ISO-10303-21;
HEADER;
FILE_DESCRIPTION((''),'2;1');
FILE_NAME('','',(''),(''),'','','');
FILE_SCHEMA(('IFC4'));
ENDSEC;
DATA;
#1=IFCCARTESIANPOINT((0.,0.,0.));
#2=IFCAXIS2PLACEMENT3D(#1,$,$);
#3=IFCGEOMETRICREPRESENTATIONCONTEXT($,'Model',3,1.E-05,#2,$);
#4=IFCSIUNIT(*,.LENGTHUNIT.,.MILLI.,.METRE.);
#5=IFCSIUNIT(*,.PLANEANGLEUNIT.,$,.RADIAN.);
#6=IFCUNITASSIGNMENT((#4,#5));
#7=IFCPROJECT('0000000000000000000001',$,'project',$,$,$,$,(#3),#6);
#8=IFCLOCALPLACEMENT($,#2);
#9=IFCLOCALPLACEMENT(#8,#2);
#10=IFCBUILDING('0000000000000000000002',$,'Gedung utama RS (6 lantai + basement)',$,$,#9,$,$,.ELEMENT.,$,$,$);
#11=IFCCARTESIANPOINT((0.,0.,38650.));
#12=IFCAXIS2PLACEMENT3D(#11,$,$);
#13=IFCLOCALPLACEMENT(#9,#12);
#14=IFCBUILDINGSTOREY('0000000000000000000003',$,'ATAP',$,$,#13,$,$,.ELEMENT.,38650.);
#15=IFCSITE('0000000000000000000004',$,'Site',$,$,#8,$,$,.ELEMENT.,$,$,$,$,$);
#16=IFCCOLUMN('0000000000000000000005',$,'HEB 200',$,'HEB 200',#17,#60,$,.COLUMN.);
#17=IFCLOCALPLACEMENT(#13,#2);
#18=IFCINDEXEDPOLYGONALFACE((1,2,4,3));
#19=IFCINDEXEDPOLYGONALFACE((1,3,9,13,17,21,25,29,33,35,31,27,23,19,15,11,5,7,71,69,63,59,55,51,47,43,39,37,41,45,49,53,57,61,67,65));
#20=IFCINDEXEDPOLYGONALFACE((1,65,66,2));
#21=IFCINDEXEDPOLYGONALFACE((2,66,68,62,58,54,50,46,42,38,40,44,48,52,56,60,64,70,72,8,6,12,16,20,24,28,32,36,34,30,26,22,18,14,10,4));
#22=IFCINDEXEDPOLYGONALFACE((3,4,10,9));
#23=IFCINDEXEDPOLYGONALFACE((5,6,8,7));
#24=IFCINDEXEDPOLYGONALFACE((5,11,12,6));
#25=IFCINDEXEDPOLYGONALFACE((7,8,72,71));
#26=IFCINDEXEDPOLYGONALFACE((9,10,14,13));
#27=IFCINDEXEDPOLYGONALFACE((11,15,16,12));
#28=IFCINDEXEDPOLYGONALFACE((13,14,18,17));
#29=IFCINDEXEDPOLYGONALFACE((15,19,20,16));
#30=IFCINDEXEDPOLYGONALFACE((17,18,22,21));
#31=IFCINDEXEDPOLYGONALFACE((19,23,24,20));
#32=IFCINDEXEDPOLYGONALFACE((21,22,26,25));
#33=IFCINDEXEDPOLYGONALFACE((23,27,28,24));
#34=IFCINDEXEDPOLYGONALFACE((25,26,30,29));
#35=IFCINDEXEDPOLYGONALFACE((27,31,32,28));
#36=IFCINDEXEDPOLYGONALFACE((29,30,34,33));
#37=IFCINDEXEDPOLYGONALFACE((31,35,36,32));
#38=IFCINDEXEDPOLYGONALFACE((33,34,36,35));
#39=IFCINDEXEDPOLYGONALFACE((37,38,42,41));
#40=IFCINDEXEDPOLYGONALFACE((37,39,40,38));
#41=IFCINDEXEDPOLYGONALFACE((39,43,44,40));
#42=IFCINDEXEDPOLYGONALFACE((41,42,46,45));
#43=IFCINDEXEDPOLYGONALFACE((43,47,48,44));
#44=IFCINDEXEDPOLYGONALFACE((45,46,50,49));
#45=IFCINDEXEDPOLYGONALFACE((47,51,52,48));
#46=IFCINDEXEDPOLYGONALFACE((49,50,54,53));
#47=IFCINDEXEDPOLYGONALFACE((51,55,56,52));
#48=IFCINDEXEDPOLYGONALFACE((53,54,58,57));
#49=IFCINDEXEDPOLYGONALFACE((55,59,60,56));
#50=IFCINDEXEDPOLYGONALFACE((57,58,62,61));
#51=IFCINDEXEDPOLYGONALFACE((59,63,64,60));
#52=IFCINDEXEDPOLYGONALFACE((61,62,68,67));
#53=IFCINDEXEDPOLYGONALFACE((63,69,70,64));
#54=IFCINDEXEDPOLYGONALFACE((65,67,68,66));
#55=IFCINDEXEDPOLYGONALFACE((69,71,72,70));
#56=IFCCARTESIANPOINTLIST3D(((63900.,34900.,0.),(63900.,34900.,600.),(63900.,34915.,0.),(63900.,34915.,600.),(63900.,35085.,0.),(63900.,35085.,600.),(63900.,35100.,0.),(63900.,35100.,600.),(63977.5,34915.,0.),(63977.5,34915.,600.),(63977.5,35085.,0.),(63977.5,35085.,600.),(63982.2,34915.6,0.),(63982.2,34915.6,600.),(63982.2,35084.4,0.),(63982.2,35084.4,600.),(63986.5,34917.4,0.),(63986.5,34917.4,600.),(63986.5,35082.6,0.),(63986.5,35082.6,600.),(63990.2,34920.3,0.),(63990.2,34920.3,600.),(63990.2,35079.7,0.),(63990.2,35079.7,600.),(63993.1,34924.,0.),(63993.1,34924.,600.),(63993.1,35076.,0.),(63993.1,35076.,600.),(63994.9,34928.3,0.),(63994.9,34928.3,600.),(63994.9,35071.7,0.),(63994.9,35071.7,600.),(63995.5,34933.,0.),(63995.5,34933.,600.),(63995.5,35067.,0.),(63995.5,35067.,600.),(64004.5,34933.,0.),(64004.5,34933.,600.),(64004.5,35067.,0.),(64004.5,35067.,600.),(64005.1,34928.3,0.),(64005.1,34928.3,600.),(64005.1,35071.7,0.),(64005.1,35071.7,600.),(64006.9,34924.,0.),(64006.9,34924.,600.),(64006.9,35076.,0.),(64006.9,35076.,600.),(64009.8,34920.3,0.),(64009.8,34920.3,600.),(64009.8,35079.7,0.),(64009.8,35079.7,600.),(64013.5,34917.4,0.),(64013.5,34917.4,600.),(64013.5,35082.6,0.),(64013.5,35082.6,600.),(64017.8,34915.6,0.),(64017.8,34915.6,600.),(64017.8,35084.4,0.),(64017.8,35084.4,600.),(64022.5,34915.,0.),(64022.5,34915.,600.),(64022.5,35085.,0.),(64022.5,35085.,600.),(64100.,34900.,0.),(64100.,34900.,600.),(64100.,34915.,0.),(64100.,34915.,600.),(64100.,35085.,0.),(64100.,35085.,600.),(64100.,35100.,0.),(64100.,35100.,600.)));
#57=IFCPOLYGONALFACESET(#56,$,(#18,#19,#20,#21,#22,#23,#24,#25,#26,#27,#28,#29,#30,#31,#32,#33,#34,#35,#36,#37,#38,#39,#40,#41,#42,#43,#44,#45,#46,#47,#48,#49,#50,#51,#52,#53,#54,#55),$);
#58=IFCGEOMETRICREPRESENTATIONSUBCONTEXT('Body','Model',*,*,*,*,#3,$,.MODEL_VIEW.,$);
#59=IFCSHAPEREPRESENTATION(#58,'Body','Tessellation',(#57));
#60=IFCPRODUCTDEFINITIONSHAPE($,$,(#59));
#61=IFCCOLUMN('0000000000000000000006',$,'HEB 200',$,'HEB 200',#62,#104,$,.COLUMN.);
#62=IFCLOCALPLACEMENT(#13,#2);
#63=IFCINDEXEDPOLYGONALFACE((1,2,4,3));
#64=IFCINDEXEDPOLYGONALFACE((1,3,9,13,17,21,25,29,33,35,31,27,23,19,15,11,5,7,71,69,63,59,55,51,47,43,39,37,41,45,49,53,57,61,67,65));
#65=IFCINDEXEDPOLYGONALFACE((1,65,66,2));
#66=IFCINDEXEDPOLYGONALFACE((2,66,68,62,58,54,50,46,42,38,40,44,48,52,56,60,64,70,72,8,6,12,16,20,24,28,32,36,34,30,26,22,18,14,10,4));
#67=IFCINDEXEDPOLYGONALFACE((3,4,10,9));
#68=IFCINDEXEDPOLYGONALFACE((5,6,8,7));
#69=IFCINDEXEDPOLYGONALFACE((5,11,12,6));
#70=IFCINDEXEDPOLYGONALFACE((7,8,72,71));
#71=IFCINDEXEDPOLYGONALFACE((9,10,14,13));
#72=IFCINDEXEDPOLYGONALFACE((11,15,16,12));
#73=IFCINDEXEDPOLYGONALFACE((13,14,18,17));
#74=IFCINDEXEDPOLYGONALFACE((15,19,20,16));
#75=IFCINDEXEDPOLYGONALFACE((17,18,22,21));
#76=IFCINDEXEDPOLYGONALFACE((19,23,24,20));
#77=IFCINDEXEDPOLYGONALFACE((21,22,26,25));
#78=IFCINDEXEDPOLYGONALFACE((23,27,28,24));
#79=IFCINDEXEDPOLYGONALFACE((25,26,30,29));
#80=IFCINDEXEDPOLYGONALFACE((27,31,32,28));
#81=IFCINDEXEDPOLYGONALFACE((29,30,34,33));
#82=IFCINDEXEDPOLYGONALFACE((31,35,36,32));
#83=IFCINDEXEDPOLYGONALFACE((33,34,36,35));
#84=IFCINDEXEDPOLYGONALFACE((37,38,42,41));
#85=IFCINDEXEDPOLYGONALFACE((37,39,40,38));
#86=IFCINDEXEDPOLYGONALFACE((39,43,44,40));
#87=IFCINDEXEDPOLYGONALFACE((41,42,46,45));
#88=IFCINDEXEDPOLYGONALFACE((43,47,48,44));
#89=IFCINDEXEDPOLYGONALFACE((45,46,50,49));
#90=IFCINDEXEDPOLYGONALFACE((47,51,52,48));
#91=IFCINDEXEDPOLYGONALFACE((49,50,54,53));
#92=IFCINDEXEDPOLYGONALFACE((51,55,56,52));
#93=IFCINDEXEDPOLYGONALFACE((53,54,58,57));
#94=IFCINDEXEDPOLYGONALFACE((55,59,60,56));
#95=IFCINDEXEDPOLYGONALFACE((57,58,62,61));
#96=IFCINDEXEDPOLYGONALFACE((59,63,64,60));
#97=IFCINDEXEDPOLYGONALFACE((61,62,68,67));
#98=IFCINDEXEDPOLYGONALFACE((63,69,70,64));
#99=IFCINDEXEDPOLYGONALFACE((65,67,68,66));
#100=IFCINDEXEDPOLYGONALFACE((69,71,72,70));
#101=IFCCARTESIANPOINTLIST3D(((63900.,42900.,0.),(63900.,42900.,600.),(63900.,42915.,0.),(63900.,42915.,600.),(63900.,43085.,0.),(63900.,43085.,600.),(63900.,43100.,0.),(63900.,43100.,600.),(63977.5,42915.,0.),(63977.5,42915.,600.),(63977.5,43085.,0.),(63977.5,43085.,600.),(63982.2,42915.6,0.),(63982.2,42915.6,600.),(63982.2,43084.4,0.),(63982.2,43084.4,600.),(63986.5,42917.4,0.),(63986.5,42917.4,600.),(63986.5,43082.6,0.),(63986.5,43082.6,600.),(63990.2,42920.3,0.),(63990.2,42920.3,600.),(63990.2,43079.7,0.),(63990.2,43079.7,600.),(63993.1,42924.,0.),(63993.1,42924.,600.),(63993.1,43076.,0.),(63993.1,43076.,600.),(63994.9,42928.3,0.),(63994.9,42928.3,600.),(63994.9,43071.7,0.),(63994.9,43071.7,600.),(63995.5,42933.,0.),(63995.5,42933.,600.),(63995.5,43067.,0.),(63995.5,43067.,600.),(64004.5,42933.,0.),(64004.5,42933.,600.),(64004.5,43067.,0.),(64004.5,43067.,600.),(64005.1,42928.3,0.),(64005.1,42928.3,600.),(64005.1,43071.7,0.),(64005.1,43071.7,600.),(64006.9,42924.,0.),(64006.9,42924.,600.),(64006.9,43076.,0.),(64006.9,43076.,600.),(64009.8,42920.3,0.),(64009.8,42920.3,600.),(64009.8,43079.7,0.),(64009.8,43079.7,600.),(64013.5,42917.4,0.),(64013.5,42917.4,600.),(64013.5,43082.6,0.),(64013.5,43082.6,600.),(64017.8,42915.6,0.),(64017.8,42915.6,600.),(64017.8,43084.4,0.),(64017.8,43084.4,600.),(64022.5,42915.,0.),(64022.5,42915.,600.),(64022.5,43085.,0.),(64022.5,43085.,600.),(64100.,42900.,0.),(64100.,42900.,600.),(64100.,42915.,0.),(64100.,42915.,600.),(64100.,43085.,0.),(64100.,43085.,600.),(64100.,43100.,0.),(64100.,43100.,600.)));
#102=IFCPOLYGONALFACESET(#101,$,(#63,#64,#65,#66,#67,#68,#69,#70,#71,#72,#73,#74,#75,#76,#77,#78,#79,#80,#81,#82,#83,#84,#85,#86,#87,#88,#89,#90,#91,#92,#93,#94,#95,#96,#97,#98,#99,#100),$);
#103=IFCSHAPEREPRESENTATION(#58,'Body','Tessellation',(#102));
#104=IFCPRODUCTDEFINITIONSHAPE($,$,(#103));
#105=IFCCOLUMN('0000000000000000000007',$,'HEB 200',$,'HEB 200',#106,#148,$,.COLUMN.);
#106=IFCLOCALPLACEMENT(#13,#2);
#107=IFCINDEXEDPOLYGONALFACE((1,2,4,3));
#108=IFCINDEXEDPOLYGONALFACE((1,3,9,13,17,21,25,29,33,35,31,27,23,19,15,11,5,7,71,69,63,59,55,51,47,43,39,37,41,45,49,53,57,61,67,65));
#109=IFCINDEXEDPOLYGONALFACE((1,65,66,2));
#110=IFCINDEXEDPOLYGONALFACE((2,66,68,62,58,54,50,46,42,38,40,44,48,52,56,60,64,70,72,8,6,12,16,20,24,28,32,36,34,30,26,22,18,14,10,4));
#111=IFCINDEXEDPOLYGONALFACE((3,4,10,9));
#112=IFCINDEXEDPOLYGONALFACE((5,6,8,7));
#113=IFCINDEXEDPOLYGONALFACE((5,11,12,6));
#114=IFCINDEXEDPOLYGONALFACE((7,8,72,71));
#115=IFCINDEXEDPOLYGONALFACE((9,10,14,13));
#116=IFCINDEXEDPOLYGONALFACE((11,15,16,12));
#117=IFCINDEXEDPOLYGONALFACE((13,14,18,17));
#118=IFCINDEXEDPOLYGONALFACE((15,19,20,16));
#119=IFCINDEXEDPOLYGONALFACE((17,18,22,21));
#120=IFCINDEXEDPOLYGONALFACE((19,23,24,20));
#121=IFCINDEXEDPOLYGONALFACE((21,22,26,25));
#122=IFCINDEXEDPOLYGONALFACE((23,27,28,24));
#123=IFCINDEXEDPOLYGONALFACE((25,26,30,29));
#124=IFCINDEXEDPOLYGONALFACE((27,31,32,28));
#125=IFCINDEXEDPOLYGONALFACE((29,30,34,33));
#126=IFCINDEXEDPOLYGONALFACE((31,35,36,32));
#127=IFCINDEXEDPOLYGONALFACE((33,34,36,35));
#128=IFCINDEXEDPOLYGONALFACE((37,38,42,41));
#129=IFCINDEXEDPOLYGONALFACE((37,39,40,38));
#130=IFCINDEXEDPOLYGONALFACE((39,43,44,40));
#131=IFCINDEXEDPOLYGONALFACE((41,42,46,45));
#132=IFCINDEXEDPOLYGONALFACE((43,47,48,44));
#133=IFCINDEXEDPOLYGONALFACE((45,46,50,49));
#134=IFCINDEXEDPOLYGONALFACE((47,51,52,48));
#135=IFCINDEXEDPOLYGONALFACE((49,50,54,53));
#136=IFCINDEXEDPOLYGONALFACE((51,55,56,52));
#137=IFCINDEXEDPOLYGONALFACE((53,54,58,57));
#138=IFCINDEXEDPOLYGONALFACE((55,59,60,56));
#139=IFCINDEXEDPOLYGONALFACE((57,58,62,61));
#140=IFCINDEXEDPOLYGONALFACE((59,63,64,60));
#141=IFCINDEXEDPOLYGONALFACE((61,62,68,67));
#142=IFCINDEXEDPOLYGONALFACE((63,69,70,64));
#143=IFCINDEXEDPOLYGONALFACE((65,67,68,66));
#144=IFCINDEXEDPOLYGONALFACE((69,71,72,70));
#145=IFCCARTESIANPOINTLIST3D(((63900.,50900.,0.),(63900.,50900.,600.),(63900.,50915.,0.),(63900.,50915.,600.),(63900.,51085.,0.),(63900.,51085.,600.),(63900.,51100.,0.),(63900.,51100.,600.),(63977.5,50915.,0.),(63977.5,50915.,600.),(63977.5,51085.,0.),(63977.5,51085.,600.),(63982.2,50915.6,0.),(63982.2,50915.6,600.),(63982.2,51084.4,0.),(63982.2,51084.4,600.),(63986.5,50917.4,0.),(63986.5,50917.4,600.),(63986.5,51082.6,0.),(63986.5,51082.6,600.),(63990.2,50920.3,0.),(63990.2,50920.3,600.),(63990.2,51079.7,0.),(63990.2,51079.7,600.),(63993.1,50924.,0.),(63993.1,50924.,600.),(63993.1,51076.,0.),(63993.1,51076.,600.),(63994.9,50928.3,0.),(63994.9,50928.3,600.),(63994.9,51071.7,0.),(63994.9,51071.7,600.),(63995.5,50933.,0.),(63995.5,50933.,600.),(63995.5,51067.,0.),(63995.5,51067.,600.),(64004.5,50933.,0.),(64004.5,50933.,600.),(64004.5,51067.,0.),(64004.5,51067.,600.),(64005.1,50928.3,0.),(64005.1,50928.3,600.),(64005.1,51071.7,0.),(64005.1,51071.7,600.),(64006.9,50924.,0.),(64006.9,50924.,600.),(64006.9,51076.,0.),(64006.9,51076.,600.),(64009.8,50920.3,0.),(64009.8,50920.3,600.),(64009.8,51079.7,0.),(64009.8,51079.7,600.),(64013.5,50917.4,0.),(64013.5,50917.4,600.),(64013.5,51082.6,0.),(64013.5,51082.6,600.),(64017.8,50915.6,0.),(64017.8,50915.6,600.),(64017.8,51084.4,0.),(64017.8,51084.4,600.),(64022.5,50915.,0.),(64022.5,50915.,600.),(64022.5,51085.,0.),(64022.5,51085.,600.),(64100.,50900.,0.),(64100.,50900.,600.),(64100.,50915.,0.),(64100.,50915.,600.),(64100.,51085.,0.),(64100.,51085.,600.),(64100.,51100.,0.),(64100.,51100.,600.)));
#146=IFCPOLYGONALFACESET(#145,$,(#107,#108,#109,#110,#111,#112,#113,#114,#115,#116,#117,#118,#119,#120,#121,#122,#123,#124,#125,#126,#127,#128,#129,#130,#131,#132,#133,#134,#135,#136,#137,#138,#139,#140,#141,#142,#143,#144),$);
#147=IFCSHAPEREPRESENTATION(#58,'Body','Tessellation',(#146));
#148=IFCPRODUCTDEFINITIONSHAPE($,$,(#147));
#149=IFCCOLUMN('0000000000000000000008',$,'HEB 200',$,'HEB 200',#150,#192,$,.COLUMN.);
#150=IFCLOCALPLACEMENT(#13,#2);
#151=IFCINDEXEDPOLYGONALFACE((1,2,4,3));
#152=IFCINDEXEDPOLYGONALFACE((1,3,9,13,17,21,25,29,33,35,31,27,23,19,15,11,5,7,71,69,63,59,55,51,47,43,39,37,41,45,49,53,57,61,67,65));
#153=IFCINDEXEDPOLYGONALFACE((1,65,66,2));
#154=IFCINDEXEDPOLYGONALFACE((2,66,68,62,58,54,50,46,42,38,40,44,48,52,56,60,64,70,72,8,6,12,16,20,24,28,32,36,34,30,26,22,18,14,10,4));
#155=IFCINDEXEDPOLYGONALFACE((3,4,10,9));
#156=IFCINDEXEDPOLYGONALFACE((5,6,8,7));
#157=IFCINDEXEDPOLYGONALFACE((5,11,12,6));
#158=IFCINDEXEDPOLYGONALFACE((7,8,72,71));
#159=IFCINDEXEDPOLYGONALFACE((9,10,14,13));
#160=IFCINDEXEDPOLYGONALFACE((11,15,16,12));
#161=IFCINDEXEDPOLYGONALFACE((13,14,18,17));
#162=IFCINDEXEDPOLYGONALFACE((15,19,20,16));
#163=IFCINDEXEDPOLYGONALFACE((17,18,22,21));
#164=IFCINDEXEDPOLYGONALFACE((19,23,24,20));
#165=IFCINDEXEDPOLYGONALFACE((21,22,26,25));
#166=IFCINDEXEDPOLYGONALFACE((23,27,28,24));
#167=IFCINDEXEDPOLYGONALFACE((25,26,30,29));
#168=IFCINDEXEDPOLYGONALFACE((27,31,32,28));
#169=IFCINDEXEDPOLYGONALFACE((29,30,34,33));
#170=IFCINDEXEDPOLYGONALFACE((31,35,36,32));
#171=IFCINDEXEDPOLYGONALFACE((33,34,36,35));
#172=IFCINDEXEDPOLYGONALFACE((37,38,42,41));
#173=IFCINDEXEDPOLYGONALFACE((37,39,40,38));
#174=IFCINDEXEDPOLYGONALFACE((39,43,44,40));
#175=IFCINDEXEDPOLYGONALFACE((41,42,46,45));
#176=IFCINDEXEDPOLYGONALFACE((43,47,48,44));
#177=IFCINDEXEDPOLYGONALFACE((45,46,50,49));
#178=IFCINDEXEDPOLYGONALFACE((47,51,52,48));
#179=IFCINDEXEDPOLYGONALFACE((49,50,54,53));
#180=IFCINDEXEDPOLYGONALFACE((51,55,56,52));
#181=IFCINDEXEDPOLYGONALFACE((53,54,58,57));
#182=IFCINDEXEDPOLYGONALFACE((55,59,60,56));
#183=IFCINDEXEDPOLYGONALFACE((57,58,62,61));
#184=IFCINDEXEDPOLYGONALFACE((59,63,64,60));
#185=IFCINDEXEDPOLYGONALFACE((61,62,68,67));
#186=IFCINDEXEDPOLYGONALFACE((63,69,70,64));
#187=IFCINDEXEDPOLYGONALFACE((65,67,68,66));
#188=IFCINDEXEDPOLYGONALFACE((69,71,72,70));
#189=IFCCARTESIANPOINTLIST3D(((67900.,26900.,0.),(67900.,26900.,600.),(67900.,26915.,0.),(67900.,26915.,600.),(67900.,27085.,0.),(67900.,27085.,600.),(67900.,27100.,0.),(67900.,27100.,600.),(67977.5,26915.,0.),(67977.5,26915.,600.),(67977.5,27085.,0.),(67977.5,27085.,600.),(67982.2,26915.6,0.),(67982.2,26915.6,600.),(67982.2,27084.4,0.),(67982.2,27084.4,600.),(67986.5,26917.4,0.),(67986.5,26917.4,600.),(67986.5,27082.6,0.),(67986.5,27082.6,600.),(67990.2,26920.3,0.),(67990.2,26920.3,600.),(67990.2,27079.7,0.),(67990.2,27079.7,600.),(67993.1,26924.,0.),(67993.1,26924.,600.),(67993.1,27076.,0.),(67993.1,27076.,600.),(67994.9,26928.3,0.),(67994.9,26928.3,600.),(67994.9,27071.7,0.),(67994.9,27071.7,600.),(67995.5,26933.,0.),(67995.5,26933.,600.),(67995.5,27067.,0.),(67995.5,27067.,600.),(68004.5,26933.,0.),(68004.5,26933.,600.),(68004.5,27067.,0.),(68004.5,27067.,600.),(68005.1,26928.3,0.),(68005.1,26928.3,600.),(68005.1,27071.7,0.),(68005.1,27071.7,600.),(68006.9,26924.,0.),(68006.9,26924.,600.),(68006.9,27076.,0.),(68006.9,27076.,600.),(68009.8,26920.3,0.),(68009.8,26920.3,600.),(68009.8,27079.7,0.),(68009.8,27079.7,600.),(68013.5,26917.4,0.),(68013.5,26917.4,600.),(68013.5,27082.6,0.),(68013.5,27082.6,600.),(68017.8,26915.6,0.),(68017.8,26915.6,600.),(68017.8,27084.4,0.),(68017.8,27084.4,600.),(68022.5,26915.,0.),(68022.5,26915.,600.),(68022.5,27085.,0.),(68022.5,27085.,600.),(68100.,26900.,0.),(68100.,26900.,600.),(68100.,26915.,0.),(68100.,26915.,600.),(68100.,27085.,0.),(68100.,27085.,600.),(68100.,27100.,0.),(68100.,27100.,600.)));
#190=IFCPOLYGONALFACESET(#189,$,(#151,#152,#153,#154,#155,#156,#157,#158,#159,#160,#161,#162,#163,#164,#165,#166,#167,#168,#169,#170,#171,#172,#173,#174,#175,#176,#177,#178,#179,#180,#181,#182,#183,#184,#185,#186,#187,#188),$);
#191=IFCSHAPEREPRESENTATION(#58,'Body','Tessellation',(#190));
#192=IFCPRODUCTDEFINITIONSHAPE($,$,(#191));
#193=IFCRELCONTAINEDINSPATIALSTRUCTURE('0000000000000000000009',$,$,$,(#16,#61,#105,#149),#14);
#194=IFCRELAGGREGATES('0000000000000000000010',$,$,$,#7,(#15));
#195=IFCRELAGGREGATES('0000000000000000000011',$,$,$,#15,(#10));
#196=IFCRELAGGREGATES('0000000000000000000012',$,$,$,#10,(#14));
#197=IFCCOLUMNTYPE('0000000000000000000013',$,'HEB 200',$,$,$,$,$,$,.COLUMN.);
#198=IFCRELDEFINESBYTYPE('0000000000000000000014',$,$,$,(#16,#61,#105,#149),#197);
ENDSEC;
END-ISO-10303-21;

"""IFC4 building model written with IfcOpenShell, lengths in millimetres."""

from ifc_helpers import new_model, si_unit, frame, origin, origin_2d, place, context, subcontext, project, spatial, i_section, extrude, material_profile, profile_set, profile_usage, type_object, element, save


model = new_model("IFC4")

# Units and contexts
model_context = context("Model", 3, precision=1e-05, world=origin())
body_context = subcontext(model_context, "Body", "Model", "MODEL_VIEW")
ifc_project = project(units=[si_unit("LENGTHUNIT", "METRE", prefix="MILLI"), si_unit("PLANEANGLEUNIT", "RADIAN")], contexts=[model_context])

# Site, building, storey
site_placement = place(None, origin())
site = spatial("IfcSite", under=ifc_project, at=site_placement, Name="Site", CompositionType="ELEMENT")
building_placement = place(site_placement, origin())
building = spatial("IfcBuilding", under=site, at=building_placement, Name="Gedung utama RS (6 lantai + basement)", CompositionType="ELEMENT")
storey_placement = place(building_placement, frame((0.0, 0.0, 38650.0)))
storey = spatial("IfcBuildingStorey", under=building, at=storey_placement, Name="ATAP", CompositionType="ELEMENT", Elevation=38650.0)

# Columns
ifc_material_profile_1 = material_profile(None, i_section(OverallWidth=200.0, OverallDepth=200.0, WebThickness=9.0, FlangeThickness=15.0, FilletRadius=18.0, at=origin_2d()), Name="HEB 200")
ifc_profile_set_1 = profile_set([ifc_material_profile_1], Name="HEB 200")
ifc_profile_usage_1 = profile_usage(ifc_profile_set_1, cardinal=5)
column_type = type_object("IfcColumnType", Name="HEB 200", PredefinedType="COLUMN", material=ifc_profile_set_1)
for number, where, z_axis, x_axis, name in (
    (1, (64000.0, 35000.0, 0.0), (0.0, 0.0, 1.0), (1.0, 0.0, 0.0), "HEB 200"),
    (2, (64000.0, 43000.0, 0.0), (0.0, 0.0, 1.0), (1.0, 0.0, 0.0), "HEB 200"),
    (3, (64000.0, 51000.0, 0.0), (0.0, 0.0, 1.0), (1.0, 0.0, 0.0), "HEB 200"),
    (4, (68000.0, 27000.0, 0.0), (0.0, 0.0, 1.0), (1.0, 0.0, 0.0), "HEB 200"),
):
    element("IfcColumn", number, at=place(storey_placement, frame(where, z_axis=z_axis, x_axis=x_axis)), inside=storey, type_object=column_type, material=ifc_profile_usage_1, Name=name, ObjectType="HEB 200", PredefinedType="COLUMN", context=body_context, shape_type="SweptSolid", body=[
        extrude(i_section(OverallWidth=200.0, OverallDepth=200.0, WebThickness=9.0, FlangeThickness=15.0, FilletRadius=18.0, at=origin_2d()), origin(), (0.0, 0.0, 1.0), 600.0),
    ])

save(model, "model.ifc")
